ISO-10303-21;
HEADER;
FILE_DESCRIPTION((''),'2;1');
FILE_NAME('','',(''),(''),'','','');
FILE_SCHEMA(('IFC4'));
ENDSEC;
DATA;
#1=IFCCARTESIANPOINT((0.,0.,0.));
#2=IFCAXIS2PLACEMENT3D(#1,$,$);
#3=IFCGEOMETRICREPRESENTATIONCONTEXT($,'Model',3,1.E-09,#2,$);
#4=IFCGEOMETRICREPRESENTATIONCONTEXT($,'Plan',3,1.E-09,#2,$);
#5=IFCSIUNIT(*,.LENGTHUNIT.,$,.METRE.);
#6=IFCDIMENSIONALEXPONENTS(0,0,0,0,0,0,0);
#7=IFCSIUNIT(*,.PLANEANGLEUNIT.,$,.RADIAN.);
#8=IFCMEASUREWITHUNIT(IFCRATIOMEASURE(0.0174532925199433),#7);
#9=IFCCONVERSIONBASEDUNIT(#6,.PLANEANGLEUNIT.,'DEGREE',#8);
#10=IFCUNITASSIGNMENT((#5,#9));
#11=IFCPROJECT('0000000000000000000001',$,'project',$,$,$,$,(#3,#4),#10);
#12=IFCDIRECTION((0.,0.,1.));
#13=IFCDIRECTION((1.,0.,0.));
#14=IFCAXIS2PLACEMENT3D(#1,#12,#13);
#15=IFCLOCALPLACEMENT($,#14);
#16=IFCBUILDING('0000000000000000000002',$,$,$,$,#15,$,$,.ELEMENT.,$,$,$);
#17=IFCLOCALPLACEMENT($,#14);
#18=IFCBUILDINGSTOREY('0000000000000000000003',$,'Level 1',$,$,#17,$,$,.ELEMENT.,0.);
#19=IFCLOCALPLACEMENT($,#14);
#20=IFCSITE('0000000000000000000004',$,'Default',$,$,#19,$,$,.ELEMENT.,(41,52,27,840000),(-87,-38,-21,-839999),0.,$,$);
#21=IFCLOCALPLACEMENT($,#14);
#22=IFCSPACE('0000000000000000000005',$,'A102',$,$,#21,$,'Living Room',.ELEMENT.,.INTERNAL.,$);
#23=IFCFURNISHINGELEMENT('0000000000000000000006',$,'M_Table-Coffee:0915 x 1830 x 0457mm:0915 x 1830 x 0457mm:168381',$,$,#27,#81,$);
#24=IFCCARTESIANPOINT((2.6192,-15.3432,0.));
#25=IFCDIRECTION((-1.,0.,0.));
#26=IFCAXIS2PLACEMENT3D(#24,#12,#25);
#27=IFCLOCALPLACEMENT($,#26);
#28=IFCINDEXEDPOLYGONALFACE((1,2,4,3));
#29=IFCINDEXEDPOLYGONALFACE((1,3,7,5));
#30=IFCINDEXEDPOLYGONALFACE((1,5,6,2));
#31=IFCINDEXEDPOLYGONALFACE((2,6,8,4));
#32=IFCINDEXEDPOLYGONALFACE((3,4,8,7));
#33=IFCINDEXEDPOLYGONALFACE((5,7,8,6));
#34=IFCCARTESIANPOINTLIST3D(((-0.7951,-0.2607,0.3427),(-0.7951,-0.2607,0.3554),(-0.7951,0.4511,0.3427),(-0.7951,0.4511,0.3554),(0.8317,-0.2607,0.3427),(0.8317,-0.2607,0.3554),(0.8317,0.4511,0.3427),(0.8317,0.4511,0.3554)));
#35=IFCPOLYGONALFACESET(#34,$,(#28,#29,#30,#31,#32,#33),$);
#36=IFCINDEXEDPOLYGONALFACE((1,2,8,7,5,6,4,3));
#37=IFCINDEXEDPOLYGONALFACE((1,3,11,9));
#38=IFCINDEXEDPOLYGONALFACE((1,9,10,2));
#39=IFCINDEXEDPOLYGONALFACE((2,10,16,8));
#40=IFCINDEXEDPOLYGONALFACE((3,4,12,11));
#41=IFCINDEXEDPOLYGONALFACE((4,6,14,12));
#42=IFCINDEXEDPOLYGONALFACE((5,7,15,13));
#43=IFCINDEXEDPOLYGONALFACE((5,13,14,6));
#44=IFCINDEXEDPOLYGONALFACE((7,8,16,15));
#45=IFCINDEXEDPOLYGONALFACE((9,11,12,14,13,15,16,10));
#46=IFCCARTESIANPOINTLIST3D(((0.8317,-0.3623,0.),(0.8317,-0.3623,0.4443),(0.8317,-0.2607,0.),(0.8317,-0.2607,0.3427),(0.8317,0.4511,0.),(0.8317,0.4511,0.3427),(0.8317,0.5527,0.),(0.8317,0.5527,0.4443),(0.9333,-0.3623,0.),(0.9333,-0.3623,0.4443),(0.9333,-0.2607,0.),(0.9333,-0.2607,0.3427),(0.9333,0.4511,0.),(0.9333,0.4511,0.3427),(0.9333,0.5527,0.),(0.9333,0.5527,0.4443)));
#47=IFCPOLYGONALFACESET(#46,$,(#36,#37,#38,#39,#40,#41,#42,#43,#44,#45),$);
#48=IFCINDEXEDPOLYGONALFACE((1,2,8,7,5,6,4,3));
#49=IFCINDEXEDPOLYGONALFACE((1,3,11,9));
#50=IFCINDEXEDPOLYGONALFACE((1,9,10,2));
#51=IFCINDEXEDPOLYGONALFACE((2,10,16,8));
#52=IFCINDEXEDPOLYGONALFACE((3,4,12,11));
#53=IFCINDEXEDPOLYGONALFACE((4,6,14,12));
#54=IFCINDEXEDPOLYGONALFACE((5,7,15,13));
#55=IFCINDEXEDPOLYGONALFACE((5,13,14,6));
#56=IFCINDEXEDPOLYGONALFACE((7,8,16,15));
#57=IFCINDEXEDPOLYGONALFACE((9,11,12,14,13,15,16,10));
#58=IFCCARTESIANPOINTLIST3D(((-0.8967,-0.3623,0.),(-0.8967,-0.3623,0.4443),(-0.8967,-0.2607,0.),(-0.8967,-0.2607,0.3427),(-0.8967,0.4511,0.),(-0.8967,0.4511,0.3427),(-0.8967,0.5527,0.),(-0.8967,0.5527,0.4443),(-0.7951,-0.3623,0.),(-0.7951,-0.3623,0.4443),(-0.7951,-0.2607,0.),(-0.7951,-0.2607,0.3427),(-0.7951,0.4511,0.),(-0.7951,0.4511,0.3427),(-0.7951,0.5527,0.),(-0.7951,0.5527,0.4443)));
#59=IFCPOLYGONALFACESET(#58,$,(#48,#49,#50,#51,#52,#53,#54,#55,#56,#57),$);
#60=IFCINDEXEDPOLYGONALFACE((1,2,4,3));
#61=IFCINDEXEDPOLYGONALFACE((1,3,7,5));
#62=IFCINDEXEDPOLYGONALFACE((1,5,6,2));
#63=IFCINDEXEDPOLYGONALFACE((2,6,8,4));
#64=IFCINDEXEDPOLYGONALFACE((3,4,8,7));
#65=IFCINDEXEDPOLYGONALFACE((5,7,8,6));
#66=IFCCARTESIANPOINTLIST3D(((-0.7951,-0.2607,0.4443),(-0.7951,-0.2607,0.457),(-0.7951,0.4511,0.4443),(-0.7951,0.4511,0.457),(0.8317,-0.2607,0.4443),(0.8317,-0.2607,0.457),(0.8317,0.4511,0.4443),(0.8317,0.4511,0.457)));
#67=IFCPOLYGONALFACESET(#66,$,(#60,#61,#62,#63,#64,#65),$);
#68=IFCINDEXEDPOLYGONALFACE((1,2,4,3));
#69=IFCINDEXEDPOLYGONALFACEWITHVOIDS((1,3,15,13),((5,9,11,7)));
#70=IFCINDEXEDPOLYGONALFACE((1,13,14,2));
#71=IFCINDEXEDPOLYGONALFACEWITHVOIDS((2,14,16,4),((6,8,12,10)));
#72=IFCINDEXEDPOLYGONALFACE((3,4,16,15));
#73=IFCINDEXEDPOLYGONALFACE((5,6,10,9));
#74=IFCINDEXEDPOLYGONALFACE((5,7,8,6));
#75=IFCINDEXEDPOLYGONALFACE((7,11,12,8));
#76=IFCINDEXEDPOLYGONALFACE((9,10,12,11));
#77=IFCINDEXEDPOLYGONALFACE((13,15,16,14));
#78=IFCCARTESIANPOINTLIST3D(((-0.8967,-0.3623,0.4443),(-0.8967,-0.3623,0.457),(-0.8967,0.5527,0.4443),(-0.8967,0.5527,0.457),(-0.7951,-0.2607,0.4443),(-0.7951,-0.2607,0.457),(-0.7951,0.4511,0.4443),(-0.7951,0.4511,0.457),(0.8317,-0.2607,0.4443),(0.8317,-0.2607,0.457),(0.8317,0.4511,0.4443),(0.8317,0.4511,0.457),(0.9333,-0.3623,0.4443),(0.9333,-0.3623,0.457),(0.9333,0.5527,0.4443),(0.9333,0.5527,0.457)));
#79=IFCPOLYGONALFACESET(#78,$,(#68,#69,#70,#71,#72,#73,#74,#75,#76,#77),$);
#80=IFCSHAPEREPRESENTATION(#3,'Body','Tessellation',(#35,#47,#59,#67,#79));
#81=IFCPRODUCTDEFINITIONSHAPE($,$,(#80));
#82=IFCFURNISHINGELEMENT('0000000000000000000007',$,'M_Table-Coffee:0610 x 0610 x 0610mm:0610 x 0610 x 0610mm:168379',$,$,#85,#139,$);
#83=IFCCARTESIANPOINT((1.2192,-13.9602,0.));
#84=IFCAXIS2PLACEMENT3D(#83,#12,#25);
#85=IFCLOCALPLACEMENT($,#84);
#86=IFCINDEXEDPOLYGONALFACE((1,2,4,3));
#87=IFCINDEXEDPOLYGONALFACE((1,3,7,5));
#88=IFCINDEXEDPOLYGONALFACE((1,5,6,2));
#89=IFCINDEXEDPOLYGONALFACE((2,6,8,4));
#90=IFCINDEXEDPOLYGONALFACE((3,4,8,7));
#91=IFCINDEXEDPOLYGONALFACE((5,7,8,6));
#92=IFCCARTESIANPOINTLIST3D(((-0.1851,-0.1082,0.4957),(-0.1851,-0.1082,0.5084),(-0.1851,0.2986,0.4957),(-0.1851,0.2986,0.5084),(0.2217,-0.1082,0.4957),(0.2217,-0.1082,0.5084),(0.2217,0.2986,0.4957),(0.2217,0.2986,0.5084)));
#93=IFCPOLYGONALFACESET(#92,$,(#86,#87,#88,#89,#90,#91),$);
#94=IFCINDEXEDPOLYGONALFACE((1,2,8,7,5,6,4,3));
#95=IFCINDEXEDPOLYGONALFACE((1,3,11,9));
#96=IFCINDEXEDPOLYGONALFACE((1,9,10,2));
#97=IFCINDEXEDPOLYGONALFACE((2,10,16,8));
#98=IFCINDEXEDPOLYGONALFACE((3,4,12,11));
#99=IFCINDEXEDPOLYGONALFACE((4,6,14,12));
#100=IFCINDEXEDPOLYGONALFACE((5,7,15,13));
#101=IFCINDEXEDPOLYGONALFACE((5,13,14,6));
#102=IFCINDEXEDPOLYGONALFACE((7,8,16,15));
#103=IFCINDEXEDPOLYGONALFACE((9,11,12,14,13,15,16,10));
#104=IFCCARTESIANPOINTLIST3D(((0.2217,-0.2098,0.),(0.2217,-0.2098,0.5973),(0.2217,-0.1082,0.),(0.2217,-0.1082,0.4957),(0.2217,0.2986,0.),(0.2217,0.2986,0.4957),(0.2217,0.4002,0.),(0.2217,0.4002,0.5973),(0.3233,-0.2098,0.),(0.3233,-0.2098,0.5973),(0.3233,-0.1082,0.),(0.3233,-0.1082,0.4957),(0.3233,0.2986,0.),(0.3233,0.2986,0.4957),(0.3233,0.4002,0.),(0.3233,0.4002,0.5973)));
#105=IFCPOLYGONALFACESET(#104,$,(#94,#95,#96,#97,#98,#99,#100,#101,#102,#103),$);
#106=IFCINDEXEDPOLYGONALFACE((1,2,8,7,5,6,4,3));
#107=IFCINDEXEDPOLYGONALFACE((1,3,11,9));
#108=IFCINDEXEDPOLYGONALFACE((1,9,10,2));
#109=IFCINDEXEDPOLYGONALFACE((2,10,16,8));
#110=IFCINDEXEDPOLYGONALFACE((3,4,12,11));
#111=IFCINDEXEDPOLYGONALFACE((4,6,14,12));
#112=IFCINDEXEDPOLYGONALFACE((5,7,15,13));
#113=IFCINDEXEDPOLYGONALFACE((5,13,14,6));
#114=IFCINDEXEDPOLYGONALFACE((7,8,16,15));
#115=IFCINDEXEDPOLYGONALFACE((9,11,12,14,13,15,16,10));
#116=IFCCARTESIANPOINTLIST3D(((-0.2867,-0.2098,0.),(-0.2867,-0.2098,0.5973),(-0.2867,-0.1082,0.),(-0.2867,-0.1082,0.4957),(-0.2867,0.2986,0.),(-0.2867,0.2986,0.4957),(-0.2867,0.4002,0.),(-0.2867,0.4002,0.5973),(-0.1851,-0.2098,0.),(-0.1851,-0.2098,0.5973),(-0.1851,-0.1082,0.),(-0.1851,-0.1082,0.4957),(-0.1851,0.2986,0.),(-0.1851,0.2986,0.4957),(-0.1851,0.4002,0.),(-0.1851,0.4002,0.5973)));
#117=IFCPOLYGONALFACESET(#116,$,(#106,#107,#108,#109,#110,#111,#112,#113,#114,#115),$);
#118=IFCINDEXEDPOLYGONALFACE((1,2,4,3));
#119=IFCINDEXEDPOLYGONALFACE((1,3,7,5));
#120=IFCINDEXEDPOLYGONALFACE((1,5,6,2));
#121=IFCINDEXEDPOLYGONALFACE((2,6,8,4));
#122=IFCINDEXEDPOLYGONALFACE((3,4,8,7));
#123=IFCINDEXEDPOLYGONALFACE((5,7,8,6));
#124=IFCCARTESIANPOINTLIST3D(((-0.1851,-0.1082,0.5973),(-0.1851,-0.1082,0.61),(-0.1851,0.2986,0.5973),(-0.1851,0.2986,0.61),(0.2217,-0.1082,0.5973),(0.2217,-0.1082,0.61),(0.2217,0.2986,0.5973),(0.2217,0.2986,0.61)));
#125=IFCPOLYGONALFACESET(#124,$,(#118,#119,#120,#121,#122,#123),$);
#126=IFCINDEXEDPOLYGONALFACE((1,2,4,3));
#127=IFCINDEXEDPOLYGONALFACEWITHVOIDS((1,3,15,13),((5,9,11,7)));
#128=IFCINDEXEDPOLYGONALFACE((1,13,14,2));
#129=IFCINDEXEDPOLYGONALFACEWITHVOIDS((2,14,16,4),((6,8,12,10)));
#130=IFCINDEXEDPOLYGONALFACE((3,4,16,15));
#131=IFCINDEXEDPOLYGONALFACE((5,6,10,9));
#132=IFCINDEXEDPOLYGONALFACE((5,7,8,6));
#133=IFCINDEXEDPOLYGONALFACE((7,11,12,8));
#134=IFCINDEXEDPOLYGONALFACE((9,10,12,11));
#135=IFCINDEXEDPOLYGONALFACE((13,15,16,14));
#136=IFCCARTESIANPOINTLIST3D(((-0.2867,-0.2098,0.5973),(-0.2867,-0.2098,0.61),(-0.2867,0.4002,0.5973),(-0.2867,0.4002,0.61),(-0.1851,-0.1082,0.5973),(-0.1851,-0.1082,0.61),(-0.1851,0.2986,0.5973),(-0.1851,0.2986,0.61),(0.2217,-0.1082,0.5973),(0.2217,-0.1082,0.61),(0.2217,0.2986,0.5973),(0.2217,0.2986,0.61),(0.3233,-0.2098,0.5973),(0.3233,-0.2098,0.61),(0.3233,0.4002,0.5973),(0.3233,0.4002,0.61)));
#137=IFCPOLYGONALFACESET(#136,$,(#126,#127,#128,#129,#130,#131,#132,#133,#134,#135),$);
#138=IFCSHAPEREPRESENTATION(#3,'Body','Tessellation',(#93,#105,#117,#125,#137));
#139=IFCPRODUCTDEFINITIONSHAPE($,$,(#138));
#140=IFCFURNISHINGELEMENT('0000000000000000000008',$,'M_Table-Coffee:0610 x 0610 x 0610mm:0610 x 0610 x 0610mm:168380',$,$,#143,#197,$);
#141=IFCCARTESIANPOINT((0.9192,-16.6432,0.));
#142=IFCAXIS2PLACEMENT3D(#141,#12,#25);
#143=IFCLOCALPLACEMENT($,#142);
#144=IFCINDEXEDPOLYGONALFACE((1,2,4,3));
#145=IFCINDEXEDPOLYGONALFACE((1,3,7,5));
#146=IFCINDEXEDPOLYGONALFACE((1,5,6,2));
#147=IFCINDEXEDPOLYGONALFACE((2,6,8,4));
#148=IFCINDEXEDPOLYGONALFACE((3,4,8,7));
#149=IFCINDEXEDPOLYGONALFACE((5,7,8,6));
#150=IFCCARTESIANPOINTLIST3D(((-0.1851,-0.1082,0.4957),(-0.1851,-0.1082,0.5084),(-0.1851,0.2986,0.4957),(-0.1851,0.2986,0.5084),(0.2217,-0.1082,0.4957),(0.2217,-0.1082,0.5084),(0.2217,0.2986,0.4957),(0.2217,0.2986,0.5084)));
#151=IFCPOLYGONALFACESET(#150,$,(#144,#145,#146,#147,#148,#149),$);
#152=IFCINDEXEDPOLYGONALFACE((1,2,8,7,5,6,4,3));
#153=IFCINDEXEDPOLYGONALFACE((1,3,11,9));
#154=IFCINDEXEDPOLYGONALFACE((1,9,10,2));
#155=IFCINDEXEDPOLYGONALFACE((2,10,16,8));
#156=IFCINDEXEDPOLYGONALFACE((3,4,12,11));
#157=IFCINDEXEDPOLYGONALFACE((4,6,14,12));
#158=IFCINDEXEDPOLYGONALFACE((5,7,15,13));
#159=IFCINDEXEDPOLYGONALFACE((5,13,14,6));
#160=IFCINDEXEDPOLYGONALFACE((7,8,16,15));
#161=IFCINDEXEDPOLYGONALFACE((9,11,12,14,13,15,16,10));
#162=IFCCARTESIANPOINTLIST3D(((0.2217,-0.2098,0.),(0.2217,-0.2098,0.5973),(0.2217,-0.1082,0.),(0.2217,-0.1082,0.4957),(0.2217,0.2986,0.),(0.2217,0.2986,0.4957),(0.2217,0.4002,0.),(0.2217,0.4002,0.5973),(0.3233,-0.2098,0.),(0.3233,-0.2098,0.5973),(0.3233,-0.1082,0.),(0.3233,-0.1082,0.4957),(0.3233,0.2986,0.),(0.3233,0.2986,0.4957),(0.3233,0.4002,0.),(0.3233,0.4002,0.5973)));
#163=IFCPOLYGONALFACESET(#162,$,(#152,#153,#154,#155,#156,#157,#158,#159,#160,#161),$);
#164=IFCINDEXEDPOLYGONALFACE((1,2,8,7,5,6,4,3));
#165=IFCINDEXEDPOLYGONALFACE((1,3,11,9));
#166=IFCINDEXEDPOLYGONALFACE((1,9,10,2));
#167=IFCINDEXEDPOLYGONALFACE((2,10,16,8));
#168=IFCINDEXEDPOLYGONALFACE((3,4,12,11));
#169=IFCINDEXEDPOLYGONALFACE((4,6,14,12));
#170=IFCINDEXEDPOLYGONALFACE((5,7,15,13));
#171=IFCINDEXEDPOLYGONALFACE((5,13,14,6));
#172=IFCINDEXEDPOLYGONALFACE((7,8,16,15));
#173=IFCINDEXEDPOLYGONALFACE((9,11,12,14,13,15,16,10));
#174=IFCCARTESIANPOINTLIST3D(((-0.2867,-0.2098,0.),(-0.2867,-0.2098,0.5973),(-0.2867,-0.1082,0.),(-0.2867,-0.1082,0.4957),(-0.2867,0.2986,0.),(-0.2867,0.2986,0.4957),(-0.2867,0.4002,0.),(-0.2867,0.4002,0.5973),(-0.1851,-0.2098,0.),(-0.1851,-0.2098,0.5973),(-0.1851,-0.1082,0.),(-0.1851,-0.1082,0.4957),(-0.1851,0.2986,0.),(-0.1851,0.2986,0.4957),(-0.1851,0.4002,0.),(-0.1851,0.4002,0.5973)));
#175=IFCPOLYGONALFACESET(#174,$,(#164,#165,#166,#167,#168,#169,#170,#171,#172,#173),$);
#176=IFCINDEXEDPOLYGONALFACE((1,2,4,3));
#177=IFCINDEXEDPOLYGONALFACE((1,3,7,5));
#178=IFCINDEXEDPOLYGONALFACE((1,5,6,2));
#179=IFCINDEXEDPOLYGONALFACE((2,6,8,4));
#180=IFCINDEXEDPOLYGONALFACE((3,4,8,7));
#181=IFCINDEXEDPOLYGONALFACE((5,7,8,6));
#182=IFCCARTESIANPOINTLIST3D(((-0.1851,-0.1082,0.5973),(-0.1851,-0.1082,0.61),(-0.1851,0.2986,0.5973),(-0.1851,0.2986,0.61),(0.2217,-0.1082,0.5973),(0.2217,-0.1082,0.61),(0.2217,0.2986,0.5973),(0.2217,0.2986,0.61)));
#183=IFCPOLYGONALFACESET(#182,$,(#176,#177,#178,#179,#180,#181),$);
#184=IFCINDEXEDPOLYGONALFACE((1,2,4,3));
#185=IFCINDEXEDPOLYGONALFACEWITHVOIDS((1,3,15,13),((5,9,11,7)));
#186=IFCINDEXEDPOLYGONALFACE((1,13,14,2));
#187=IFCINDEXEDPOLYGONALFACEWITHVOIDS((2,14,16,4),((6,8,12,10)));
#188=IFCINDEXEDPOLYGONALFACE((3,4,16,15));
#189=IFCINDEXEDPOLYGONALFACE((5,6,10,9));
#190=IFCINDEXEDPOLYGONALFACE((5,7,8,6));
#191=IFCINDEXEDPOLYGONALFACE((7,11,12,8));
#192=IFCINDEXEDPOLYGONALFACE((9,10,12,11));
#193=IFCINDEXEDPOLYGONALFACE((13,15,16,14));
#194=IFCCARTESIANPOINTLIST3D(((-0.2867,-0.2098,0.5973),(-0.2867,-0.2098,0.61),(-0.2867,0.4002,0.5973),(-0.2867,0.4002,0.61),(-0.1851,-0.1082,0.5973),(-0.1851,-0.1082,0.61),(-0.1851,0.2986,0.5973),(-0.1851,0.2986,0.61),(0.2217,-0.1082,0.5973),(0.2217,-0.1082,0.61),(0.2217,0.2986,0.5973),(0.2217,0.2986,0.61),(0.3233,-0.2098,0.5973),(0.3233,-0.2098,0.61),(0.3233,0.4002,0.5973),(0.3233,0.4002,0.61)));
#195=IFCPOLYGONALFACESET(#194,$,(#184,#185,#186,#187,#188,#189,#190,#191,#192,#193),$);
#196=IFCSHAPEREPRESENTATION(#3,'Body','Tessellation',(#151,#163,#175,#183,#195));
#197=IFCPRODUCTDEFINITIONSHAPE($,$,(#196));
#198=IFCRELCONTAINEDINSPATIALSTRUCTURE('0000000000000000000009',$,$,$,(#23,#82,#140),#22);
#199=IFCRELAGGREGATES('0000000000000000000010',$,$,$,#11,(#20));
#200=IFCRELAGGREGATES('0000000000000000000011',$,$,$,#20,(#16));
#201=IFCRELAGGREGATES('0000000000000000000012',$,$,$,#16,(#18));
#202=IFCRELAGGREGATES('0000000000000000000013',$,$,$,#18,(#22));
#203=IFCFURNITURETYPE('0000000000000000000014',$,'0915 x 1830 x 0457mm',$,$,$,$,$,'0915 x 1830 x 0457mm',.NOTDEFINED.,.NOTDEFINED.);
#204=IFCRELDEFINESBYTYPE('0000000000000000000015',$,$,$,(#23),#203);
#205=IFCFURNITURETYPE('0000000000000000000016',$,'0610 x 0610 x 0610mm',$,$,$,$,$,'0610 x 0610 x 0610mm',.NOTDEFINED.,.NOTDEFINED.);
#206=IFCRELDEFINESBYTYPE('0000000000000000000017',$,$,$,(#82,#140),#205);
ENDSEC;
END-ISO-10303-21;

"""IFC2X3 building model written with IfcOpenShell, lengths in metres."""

from ifc_helpers import new_model, entity, si_unit, converted_unit, frame, origin, origin_with_axes, origin_2d_with_axis, place, context, project, spatial, polyline, rectangle, outline, extrude, source, transform, mapped, type_object, type_shapes, element, save


model = new_model("IFC2X3")

# Units and contexts
model_context = context("Model", 3, precision=1e-09, world=origin())
plan_context = context("Plan", 3, precision=1e-09, world=origin())
ifc_project = project(units=[si_unit("LENGTHUNIT", "METRE"), converted_unit("PLANEANGLEUNIT", "DEGREE", entity("IfcRatioMeasure", 0.0174532925199433), si_unit("PLANEANGLEUNIT", "RADIAN"), dimensions=[0, 0, 0, 0, 0, 0, 0])], contexts=[model_context, plan_context])

# Site, building, storey, space
site_placement = place(None, origin_with_axes())
site = spatial("IfcSite", under=ifc_project, at=site_placement, Name="Default", CompositionType="ELEMENT", RefLatitude=(41, 52, 27, 840000), RefLongitude=(-87, -38, -21, -839999), RefElevation=0.0)
building_placement = place(None, origin_with_axes())
building = spatial("IfcBuilding", under=site, at=building_placement, CompositionType="ELEMENT")
storey_placement = place(None, origin_with_axes())
storey = spatial("IfcBuildingStorey", under=building, at=storey_placement, Name="Level 1", CompositionType="ELEMENT", Elevation=0.0)
space_placement = place(None, origin_with_axes())
space = spatial("IfcSpace", under=storey, at=space_placement, Name="A102", LongName="Living Room", CompositionType="ELEMENT", InteriorOrExteriorSpace="INTERNAL")

# Furnishing elements
furniture_type_1 = type_object("IfcFurnitureType", Name="0915 x 1830 x 0457mm", ElementType="0915 x 1830 x 0457mm", AssemblyPlace="NOTDEFINED")
shared_shape_1 = source(origin(), model_context, "Body", "SweptSolid", [
    extrude(rectangle(XDim=1.6268, YDim=0.7118, at=origin_2d_with_axis()), frame((0.0183, 0.0952, 0.3427), z_axis=(0.0, 0.0, 1.0), x_axis=(-1.0, 0.0, 0.0)), (0.0, 0.0, 1.0), 0.0127),
    extrude(outline(polyline([(-0.1967, -0.4575), (0.2475, -0.4575), (0.2475, 0.4575), (-0.1967, 0.4575), (-0.1967, 0.3559), (0.146, 0.3559), (0.146, -0.3559), (-0.1967, -0.3559), (-0.1967, -0.4575)])), frame((0.8317, 0.0952, 0.1967), z_axis=(1.0, 0.0, 0.0), x_axis=(0.0, 0.0, 1.0)), (0.0, 0.0, 1.0), 0.1016),
    extrude(outline(polyline([(-0.4575, -0.2476), (0.4575, -0.2476), (0.4575, 0.1968), (0.3559, 0.1968), (0.3559, -0.1459), (-0.3559, -0.1459), (-0.3559, 0.1968), (-0.4575, 0.1968), (-0.4575, -0.2476)])), frame((-0.8967, 0.0952, 0.1968), z_axis=(1.0, 0.0, 0.0), x_axis=(0.0, -1.0, 0.0)), (0.0, 0.0, 1.0), 0.1016),
    extrude(rectangle(XDim=1.6268, YDim=0.7118, at=origin_2d_with_axis()), frame((0.0183, 0.0952, 0.4443), z_axis=(0.0, 0.0, 1.0), x_axis=(-1.0, 0.0, 0.0)), (0.0, 0.0, 1.0), 0.0127),
    extrude(outline(polyline([(-0.915, -0.4575), (0.915, -0.4575), (0.915, 0.4575), (-0.915, 0.4575), (-0.915, -0.4575)]), holes=[polyline([(-0.8134, -0.3559), (-0.8134, 0.3559), (0.8134, 0.3559), (0.8134, -0.3559), (-0.8134, -0.3559)])]), frame((0.0183, 0.0952, 0.4443), z_axis=(0.0, 0.0, 1.0), x_axis=(-1.0, 0.0, 0.0)), (0.0, 0.0, 1.0), 0.0127),
])
type_shapes(furniture_type_1, [shared_shape_1])
furnishing_placement = place(None, frame((2.6192, -15.3432, 0.0), z_axis=(0.0, 0.0, 1.0), x_axis=(-1.0, 0.0, 0.0)))
element("IfcFurnishingElement", 1, at=furnishing_placement, inside=space, type_object=furniture_type_1, Name="M_Table-Coffee:0915 x 1830 x 0457mm:0915 x 1830 x 0457mm:168381", context=model_context, shape_type="MappedRepresentation", body=[
    mapped(shared_shape_1, transform((0.0, 0.0, 0.0), scale=1.0)),
])
furniture_type_2 = type_object("IfcFurnitureType", Name="0610 x 0610 x 0610mm", ElementType="0610 x 0610 x 0610mm", AssemblyPlace="NOTDEFINED")
shared_shape_2 = source(origin(), model_context, "Body", "SweptSolid", [
    extrude(rectangle(XDim=0.4068, YDim=0.4068, at=origin_2d_with_axis()), frame((0.0183, 0.0952, 0.4957), z_axis=(0.0, 0.0, 1.0), x_axis=(-1.0, 0.0, 0.0)), (0.0, 0.0, 1.0), 0.0127),
    extrude(outline(polyline([(-0.2732, -0.305), (0.324, -0.305), (0.324, 0.305), (-0.2732, 0.305), (-0.2732, 0.2034), (0.2225, 0.2034), (0.2225, -0.2034), (-0.2732, -0.2034), (-0.2732, -0.305)])), frame((0.2217, 0.0952, 0.2732), z_axis=(1.0, 0.0, 0.0), x_axis=(0.0, 0.0, 1.0)), (0.0, 0.0, 1.0), 0.1016),
    extrude(outline(polyline([(-0.305, -0.3241), (0.305, -0.3241), (0.305, 0.2733), (0.2034, 0.2733), (0.2034, -0.2224), (-0.2034, -0.2224), (-0.2034, 0.2733), (-0.305, 0.2733), (-0.305, -0.3241)])), frame((-0.2867, 0.0952, 0.2733), z_axis=(1.0, 0.0, 0.0), x_axis=(0.0, -1.0, 0.0)), (0.0, 0.0, 1.0), 0.1016),
    extrude(rectangle(XDim=0.4068, YDim=0.4068, at=origin_2d_with_axis()), frame((0.0183, 0.0952, 0.5973), z_axis=(0.0, 0.0, 1.0), x_axis=(-1.0, 0.0, 0.0)), (0.0, 0.0, 1.0), 0.0127),
    extrude(outline(polyline([(-0.305, -0.305), (0.305, -0.305), (0.305, 0.305), (-0.305, 0.305), (-0.305, -0.305)]), holes=[polyline([(-0.2034, -0.2034), (-0.2034, 0.2034), (0.2034, 0.2034), (0.2034, -0.2034), (-0.2034, -0.2034)])]), frame((0.0183, 0.0952, 0.5973), z_axis=(0.0, 0.0, 1.0), x_axis=(-1.0, 0.0, 0.0)), (0.0, 0.0, 1.0), 0.0127),
])
type_shapes(furniture_type_2, [shared_shape_2])
for number, where, z_axis, x_axis, name in (
    (2, (1.2192, -13.9602, 0.0), (0.0, 0.0, 1.0), (-1.0, 0.0, 0.0), "M_Table-Coffee:0610 x 0610 x 0610mm:0610 x 0610 x 0610mm:168379"),
    (3, (0.9192, -16.6432, 0.0), (0.0, 0.0, 1.0), (-1.0, 0.0, 0.0), "M_Table-Coffee:0610 x 0610 x 0610mm:0610 x 0610 x 0610mm:168380"),
):
    element("IfcFurnishingElement", number, at=place(None, frame(where, z_axis=z_axis, x_axis=x_axis)), inside=space, type_object=furniture_type_2, Name=name, context=model_context, shape_type="MappedRepresentation", body=[
        mapped(shared_shape_2, transform((0.0, 0.0, 0.0), scale=1.0)),
    ])

save(model, "model.ifc")
